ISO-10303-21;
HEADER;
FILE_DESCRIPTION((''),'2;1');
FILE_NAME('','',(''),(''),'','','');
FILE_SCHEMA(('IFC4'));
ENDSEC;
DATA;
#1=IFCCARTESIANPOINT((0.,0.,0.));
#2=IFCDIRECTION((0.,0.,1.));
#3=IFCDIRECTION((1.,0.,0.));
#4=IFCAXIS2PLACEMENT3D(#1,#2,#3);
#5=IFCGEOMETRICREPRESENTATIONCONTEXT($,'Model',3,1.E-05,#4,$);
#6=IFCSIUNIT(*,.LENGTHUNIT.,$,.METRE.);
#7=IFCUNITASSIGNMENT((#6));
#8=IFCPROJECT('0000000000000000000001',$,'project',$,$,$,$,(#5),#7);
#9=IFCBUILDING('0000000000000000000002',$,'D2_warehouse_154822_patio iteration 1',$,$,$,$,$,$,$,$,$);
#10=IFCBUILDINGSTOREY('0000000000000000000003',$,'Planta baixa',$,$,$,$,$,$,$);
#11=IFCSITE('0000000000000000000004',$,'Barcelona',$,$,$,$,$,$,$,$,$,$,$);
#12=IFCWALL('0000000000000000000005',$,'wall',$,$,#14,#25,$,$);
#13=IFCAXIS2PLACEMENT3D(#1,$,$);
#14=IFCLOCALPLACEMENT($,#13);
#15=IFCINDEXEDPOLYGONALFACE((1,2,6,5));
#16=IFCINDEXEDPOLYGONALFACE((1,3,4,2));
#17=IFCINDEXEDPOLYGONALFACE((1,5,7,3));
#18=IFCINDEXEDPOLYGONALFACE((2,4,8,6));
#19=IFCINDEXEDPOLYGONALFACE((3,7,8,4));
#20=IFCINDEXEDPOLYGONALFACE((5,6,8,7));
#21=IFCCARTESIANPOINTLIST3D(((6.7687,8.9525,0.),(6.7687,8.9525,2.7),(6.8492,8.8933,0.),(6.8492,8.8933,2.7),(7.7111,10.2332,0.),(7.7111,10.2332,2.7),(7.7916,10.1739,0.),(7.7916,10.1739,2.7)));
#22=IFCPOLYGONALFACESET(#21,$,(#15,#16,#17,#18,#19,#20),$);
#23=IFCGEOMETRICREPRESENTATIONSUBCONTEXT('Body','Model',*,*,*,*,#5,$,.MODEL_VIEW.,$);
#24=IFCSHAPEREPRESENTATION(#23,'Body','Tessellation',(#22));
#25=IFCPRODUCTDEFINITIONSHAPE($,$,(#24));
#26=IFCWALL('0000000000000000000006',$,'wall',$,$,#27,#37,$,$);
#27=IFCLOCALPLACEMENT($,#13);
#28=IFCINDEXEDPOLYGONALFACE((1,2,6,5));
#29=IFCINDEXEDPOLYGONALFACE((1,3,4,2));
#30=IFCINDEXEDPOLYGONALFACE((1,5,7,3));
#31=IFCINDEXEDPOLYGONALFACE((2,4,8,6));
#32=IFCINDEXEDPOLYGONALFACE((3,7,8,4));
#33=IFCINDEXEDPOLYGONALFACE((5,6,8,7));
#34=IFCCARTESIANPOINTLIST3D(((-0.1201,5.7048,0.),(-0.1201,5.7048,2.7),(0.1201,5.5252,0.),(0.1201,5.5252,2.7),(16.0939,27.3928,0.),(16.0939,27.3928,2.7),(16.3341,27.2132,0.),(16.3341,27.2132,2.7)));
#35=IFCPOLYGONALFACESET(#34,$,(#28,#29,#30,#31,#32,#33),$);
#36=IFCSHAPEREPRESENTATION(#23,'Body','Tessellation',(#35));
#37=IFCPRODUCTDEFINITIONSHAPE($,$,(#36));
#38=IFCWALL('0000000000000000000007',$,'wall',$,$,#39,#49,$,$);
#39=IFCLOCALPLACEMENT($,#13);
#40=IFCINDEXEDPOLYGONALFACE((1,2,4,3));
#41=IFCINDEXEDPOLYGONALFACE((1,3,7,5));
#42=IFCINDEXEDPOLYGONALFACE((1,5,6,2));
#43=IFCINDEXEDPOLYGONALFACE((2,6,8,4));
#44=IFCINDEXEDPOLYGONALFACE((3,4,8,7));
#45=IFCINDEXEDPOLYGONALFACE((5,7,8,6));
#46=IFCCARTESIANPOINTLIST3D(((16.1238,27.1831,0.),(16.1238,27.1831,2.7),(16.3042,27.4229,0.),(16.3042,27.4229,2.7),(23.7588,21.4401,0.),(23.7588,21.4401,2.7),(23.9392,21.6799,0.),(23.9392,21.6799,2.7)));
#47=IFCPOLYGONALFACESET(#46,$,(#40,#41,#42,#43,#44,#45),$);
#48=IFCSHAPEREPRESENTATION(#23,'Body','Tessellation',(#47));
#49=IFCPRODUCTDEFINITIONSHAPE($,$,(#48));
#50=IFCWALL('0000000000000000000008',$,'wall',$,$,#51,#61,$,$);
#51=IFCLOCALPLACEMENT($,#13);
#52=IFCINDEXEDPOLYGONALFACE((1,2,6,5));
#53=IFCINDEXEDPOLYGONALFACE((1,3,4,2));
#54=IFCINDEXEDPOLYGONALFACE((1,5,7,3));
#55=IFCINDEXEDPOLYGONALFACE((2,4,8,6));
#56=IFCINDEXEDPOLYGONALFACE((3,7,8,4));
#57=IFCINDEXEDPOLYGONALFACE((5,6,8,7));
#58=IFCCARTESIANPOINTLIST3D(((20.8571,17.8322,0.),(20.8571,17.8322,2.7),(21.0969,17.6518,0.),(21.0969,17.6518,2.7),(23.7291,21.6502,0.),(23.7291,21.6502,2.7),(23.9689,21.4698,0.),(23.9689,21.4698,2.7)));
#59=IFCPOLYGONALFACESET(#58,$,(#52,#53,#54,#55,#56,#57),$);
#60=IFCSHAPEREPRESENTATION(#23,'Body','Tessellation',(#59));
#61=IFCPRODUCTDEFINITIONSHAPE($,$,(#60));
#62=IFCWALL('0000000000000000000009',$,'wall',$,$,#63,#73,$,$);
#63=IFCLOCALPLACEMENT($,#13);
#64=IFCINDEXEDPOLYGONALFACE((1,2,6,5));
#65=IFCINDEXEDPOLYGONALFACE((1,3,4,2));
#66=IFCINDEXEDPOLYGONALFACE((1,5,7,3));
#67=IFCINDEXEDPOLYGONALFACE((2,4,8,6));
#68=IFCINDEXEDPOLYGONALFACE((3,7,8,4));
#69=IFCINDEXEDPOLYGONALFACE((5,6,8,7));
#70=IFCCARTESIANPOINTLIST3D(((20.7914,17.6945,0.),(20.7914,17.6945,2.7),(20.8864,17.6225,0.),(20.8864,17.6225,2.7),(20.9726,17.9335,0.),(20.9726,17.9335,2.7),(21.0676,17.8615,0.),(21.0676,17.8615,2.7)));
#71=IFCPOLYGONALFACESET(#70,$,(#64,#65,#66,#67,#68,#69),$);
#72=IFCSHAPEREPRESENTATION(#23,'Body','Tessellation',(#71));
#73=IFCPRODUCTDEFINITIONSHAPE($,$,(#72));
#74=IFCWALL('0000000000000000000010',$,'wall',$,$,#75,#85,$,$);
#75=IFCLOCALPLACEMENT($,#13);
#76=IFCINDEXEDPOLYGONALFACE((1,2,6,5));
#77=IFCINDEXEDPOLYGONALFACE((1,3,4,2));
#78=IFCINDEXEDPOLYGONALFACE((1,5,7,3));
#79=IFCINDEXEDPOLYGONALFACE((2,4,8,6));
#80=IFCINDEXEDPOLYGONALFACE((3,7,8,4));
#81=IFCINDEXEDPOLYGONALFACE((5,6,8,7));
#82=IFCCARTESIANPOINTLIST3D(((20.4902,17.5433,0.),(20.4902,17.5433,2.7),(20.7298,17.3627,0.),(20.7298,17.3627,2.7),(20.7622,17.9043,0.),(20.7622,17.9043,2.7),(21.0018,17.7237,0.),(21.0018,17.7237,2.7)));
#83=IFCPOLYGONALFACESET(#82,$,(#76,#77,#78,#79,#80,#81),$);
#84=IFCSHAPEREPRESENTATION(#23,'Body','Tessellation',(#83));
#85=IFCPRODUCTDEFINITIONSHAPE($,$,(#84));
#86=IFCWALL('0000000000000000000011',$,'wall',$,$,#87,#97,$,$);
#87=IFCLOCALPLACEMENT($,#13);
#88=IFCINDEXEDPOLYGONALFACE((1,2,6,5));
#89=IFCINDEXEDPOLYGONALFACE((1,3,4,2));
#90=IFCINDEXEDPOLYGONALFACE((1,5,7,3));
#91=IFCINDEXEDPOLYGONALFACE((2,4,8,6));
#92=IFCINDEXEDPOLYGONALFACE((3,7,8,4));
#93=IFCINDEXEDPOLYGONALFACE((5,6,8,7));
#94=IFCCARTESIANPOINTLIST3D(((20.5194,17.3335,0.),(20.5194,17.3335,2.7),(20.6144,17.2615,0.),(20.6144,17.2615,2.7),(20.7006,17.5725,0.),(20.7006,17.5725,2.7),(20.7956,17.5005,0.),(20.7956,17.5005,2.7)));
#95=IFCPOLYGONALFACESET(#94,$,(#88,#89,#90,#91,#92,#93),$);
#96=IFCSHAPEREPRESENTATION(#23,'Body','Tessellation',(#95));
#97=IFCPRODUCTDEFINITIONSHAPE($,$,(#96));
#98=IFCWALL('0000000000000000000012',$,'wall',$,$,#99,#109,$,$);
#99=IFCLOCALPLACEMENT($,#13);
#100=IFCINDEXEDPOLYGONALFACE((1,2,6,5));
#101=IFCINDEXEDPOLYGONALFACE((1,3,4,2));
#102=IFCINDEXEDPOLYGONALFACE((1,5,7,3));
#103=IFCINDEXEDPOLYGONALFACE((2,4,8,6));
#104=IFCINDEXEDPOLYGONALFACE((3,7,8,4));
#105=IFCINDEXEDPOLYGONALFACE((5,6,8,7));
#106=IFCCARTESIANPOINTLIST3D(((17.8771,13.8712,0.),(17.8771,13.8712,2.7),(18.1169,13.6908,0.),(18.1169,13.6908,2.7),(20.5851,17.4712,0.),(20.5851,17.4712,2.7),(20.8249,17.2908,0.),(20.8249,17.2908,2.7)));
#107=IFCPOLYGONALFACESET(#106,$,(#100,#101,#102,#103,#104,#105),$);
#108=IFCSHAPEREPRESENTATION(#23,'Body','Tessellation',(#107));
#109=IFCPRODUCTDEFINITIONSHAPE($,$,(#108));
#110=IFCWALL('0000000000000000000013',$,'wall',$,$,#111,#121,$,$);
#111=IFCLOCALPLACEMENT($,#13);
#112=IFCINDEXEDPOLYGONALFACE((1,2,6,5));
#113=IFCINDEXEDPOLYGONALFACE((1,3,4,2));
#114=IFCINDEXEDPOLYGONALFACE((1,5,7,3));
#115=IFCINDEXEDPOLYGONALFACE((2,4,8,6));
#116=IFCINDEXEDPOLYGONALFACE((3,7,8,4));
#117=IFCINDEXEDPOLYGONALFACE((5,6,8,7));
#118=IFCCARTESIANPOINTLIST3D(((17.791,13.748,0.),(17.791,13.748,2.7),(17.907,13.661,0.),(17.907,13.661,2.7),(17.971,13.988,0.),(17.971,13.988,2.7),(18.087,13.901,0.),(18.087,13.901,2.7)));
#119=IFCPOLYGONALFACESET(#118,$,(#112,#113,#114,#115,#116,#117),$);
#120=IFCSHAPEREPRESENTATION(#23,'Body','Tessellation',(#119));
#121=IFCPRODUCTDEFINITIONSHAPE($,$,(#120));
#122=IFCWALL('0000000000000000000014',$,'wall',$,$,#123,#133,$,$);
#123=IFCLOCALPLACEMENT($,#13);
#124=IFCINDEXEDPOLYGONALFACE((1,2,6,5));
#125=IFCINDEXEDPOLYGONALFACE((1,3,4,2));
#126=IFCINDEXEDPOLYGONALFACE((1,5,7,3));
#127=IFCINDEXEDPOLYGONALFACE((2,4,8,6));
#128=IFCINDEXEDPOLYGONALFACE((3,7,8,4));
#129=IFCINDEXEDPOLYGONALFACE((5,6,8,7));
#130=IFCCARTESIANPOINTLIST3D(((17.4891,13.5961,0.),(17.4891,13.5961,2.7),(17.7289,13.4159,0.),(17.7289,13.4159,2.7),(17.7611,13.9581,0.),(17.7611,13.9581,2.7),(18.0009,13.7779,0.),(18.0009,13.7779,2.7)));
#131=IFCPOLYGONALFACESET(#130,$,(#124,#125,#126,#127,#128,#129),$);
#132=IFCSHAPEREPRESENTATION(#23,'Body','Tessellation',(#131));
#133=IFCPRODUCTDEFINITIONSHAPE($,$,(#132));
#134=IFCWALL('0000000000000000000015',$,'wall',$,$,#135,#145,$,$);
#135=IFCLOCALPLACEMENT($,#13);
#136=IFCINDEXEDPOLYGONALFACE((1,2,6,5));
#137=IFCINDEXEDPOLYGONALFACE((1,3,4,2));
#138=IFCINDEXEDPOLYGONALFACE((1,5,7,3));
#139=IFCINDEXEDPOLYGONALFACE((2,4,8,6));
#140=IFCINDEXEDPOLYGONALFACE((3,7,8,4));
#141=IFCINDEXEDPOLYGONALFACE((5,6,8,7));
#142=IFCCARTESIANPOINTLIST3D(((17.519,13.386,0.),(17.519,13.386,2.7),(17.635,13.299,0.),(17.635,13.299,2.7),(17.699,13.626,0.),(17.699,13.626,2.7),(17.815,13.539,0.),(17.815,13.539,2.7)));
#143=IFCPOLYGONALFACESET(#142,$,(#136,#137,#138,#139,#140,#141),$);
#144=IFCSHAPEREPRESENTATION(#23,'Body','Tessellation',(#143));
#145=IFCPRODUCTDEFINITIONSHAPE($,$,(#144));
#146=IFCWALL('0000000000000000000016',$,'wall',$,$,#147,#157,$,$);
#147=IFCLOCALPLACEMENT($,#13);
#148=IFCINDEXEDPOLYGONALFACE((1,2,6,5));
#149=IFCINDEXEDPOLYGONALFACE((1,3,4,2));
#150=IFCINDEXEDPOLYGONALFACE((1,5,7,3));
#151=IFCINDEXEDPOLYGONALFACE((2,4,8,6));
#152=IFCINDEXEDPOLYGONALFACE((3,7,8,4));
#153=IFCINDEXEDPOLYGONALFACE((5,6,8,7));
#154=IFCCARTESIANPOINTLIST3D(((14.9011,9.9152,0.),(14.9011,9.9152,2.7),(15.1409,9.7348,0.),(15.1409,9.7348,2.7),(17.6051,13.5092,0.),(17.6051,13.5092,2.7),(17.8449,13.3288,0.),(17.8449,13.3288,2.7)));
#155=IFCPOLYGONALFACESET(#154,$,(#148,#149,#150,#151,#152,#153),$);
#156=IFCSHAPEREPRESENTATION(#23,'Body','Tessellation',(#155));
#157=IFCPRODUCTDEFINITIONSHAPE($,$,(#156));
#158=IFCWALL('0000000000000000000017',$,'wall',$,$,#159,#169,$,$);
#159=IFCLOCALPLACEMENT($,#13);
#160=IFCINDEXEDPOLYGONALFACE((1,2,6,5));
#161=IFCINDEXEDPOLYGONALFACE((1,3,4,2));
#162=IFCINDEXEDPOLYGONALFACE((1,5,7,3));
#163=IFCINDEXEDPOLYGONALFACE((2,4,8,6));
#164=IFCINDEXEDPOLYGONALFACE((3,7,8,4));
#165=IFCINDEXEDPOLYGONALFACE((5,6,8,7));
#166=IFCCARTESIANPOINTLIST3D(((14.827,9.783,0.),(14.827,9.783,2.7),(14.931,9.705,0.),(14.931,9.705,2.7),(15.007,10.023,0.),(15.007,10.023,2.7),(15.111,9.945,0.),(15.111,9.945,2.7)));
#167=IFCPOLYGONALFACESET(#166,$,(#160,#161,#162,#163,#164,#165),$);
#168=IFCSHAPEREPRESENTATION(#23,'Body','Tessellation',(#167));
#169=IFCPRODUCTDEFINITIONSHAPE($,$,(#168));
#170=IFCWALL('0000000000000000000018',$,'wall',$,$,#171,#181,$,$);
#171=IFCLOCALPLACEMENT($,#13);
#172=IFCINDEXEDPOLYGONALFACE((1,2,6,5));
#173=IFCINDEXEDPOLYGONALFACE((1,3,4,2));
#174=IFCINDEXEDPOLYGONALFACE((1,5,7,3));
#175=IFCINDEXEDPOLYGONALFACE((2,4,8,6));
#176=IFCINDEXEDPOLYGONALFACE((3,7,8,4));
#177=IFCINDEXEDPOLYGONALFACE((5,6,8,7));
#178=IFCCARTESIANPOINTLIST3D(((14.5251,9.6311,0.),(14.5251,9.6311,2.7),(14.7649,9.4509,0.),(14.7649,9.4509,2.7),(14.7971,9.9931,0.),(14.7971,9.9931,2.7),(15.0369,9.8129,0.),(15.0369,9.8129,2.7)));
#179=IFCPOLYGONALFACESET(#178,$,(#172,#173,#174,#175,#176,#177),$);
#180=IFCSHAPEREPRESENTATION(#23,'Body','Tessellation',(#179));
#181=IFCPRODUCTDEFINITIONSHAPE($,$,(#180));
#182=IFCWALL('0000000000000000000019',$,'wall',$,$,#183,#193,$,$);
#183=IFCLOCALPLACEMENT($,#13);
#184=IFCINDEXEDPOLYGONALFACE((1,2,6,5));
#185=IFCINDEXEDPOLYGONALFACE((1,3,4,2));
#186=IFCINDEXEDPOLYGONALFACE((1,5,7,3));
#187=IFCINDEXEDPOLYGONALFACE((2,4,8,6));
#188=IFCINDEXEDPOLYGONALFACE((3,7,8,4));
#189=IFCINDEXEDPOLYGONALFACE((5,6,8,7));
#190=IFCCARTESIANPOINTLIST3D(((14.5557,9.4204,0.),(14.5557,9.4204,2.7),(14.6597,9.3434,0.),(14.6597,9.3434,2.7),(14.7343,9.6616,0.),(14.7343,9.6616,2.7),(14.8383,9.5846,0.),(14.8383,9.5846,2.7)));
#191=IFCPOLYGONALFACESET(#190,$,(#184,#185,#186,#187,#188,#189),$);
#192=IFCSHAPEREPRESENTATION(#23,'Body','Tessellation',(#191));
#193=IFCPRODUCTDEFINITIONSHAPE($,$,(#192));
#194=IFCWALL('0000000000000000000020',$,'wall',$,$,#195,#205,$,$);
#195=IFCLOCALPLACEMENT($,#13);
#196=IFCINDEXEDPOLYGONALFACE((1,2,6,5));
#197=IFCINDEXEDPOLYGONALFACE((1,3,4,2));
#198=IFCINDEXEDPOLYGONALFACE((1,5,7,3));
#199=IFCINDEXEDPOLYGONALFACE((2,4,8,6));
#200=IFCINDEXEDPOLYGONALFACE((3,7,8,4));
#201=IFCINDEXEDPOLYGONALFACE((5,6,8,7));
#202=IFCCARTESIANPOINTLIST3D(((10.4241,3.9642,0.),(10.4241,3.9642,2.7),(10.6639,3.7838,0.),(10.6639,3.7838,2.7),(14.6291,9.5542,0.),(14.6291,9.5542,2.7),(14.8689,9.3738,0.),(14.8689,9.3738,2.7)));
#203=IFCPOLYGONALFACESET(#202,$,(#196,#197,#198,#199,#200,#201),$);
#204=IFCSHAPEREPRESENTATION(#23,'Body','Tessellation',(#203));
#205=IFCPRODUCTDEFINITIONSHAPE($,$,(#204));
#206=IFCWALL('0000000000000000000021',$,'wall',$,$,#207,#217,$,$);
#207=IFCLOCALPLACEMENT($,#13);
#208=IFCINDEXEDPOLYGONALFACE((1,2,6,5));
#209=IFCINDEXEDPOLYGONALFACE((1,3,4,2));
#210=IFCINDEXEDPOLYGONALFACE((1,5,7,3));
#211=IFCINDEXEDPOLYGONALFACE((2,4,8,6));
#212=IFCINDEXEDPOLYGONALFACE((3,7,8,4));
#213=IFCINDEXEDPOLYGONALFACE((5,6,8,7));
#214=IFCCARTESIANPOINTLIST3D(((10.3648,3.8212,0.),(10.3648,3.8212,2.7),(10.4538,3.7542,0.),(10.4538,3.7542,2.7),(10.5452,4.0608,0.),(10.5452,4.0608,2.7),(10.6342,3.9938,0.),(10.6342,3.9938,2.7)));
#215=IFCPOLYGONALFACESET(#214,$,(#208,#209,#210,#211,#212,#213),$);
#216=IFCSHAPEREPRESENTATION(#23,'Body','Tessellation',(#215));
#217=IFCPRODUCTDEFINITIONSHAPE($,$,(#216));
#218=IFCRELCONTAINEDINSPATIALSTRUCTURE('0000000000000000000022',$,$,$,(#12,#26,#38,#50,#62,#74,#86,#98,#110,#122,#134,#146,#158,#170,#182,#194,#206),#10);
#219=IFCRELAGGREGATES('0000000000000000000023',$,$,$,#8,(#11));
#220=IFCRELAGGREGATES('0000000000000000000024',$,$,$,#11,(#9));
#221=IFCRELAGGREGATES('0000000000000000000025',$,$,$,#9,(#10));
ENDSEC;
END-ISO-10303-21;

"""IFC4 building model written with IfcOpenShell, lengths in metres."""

from ifc_helpers import new_model, si_unit, origin, origin_with_axes, place, context, subcontext, project, spatial, polyline, outline, extrude, element, save


model = new_model("IFC4")

# Units and contexts
model_context = context("Model", 3, precision=1e-05, world=origin_with_axes())
body_context = subcontext(model_context, "Body", "Model", "MODEL_VIEW")
ifc_project = project(units=[si_unit("LENGTHUNIT", "METRE")], contexts=[model_context])

# Site, building, storey
site = spatial("IfcSite", under=ifc_project, Name="Barcelona")
building = spatial("IfcBuilding", under=site, Name="D2_warehouse_154822_patio iteration 1")
storey = spatial("IfcBuildingStorey", under=building, Name="Planta baixa")

# Walls
wall_1_placement = place(None, origin_with_axes())
element("IfcWall", 1, at=wall_1_placement, inside=storey, Name="wall", context=body_context, shape_type="SweptSolid", body=[
    extrude(outline(polyline([(6.7687, 8.9525), (7.7111, 10.2332), (7.7916, 10.1739), (6.8492, 8.8933), (6.7687, 8.9525)])), origin(), (0.0, 0.0, 1.0), 2.7),
])
wall_2_placement = place(None, origin_with_axes())
element("IfcWall", 2, at=wall_2_placement, inside=storey, Name="wall", context=body_context, shape_type="SweptSolid", body=[
    extrude(outline(polyline([(-0.1201, 5.7048), (16.0939, 27.3928), (16.3341, 27.2132), (0.1201, 5.5252), (-0.1201, 5.7048)])), origin(), (0.0, 0.0, 1.0), 2.7),
])
wall_3_placement = place(None, origin_with_axes())
element("IfcWall", 3, at=wall_3_placement, inside=storey, Name="wall", context=body_context, shape_type="SweptSolid", body=[
    extrude(outline(polyline([(16.3042, 27.4229), (23.9392, 21.6799), (23.7588, 21.4401), (16.1238, 27.1831), (16.3042, 27.4229)])), origin(), (0.0, 0.0, 1.0), 2.7),
])
wall_4_placement = place(None, origin_with_axes())
element("IfcWall", 4, at=wall_4_placement, inside=storey, Name="wall", context=body_context, shape_type="SweptSolid", body=[
    extrude(outline(polyline([(23.9689, 21.4698), (21.0969, 17.6518), (20.8571, 17.8322), (23.7291, 21.6502), (23.9689, 21.4698)])), origin(), (0.0, 0.0, 1.0), 2.7),
])
wall_5_placement = place(None, origin_with_axes())
element("IfcWall", 5, at=wall_5_placement, inside=storey, Name="wall", context=body_context, shape_type="SweptSolid", body=[
    extrude(outline(polyline([(20.8864, 17.6225), (20.7914, 17.6945), (20.9726, 17.9335), (21.0676, 17.8615), (20.8864, 17.6225)])), origin(), (0.0, 0.0, 1.0), 2.7),
])
wall_6_placement = place(None, origin_with_axes())
element("IfcWall", 6, at=wall_6_placement, inside=storey, Name="wall", context=body_context, shape_type="SweptSolid", body=[
    extrude(outline(polyline([(21.0018, 17.7237), (20.7298, 17.3627), (20.4902, 17.5433), (20.7622, 17.9043), (21.0018, 17.7237)])), origin(), (0.0, 0.0, 1.0), 2.7),
])
wall_7_placement = place(None, origin_with_axes())
element("IfcWall", 7, at=wall_7_placement, inside=storey, Name="wall", context=body_context, shape_type="SweptSolid", body=[
    extrude(outline(polyline([(20.7006, 17.5725), (20.7956, 17.5005), (20.6144, 17.2615), (20.5194, 17.3335), (20.7006, 17.5725)])), origin(), (0.0, 0.0, 1.0), 2.7),
])
wall_8_placement = place(None, origin_with_axes())
element("IfcWall", 8, at=wall_8_placement, inside=storey, Name="wall", context=body_context, shape_type="SweptSolid", body=[
    extrude(outline(polyline([(20.8249, 17.2908), (18.1169, 13.6908), (17.8771, 13.8712), (20.5851, 17.4712), (20.8249, 17.2908)])), origin(), (0.0, 0.0, 1.0), 2.7),
])
wall_9_placement = place(None, origin_with_axes())
element("IfcWall", 9, at=wall_9_placement, inside=storey, Name="wall", context=body_context, shape_type="SweptSolid", body=[
    extrude(outline(polyline([(17.907, 13.661), (17.791, 13.748), (17.971, 13.988), (18.087, 13.901), (17.907, 13.661)])), origin(), (0.0, 0.0, 1.0), 2.7),
])
wall_10_placement = place(None, origin_with_axes())
element("IfcWall", 10, at=wall_10_placement, inside=storey, Name="wall", context=body_context, shape_type="SweptSolid", body=[
    extrude(outline(polyline([(18.0009, 13.7779), (17.7289, 13.4159), (17.4891, 13.5961), (17.7611, 13.9581), (18.0009, 13.7779)])), origin(), (0.0, 0.0, 1.0), 2.7),
])
wall_11_placement = place(None, origin_with_axes())
element("IfcWall", 11, at=wall_11_placement, inside=storey, Name="wall", context=body_context, shape_type="SweptSolid", body=[
    extrude(outline(polyline([(17.699, 13.626), (17.815, 13.539), (17.635, 13.299), (17.519, 13.386), (17.699, 13.626)])), origin(), (0.0, 0.0, 1.0), 2.7),
])
wall_12_placement = place(None, origin_with_axes())
element("IfcWall", 12, at=wall_12_placement, inside=storey, Name="wall", context=body_context, shape_type="SweptSolid", body=[
    extrude(outline(polyline([(17.8449, 13.3288), (15.1409, 9.7348), (14.9011, 9.9152), (17.6051, 13.5092), (17.8449, 13.3288)])), origin(), (0.0, 0.0, 1.0), 2.7),
])
wall_13_placement = place(None, origin_with_axes())
element("IfcWall", 13, at=wall_13_placement, inside=storey, Name="wall", context=body_context, shape_type="SweptSolid", body=[
    extrude(outline(polyline([(14.931, 9.705), (14.827, 9.783), (15.007, 10.023), (15.111, 9.945), (14.931, 9.705)])), origin(), (0.0, 0.0, 1.0), 2.7),
])
wall_14_placement = place(None, origin_with_axes())
element("IfcWall", 14, at=wall_14_placement, inside=storey, Name="wall", context=body_context, shape_type="SweptSolid", body=[
    extrude(outline(polyline([(15.0369, 9.8129), (14.7649, 9.4509), (14.5251, 9.6311), (14.7971, 9.9931), (15.0369, 9.8129)])), origin(), (0.0, 0.0, 1.0), 2.7),
])
wall_15_placement = place(None, origin_with_axes())
element("IfcWall", 15, at=wall_15_placement, inside=storey, Name="wall", context=body_context, shape_type="SweptSolid", body=[
    extrude(outline(polyline([(14.7343, 9.6616), (14.8383, 9.5846), (14.6597, 9.3434), (14.5557, 9.4204), (14.7343, 9.6616)])), origin(), (0.0, 0.0, 1.0), 2.7),
])
wall_16_placement = place(None, origin_with_axes())
element("IfcWall", 16, at=wall_16_placement, inside=storey, Name="wall", context=body_context, shape_type="SweptSolid", body=[
    extrude(outline(polyline([(14.8689, 9.3738), (10.6639, 3.7838), (10.4241, 3.9642), (14.6291, 9.5542), (14.8689, 9.3738)])), origin(), (0.0, 0.0, 1.0), 2.7),
])
wall_17_placement = place(None, origin_with_axes())
element("IfcWall", 17, at=wall_17_placement, inside=storey, Name="wall", context=body_context, shape_type="SweptSolid", body=[
    extrude(outline(polyline([(10.4538, 3.7542), (10.3648, 3.8212), (10.5452, 4.0608), (10.6342, 3.9938), (10.4538, 3.7542)])), origin(), (0.0, 0.0, 1.0), 2.7),
])

save(model, "model.ifc")
